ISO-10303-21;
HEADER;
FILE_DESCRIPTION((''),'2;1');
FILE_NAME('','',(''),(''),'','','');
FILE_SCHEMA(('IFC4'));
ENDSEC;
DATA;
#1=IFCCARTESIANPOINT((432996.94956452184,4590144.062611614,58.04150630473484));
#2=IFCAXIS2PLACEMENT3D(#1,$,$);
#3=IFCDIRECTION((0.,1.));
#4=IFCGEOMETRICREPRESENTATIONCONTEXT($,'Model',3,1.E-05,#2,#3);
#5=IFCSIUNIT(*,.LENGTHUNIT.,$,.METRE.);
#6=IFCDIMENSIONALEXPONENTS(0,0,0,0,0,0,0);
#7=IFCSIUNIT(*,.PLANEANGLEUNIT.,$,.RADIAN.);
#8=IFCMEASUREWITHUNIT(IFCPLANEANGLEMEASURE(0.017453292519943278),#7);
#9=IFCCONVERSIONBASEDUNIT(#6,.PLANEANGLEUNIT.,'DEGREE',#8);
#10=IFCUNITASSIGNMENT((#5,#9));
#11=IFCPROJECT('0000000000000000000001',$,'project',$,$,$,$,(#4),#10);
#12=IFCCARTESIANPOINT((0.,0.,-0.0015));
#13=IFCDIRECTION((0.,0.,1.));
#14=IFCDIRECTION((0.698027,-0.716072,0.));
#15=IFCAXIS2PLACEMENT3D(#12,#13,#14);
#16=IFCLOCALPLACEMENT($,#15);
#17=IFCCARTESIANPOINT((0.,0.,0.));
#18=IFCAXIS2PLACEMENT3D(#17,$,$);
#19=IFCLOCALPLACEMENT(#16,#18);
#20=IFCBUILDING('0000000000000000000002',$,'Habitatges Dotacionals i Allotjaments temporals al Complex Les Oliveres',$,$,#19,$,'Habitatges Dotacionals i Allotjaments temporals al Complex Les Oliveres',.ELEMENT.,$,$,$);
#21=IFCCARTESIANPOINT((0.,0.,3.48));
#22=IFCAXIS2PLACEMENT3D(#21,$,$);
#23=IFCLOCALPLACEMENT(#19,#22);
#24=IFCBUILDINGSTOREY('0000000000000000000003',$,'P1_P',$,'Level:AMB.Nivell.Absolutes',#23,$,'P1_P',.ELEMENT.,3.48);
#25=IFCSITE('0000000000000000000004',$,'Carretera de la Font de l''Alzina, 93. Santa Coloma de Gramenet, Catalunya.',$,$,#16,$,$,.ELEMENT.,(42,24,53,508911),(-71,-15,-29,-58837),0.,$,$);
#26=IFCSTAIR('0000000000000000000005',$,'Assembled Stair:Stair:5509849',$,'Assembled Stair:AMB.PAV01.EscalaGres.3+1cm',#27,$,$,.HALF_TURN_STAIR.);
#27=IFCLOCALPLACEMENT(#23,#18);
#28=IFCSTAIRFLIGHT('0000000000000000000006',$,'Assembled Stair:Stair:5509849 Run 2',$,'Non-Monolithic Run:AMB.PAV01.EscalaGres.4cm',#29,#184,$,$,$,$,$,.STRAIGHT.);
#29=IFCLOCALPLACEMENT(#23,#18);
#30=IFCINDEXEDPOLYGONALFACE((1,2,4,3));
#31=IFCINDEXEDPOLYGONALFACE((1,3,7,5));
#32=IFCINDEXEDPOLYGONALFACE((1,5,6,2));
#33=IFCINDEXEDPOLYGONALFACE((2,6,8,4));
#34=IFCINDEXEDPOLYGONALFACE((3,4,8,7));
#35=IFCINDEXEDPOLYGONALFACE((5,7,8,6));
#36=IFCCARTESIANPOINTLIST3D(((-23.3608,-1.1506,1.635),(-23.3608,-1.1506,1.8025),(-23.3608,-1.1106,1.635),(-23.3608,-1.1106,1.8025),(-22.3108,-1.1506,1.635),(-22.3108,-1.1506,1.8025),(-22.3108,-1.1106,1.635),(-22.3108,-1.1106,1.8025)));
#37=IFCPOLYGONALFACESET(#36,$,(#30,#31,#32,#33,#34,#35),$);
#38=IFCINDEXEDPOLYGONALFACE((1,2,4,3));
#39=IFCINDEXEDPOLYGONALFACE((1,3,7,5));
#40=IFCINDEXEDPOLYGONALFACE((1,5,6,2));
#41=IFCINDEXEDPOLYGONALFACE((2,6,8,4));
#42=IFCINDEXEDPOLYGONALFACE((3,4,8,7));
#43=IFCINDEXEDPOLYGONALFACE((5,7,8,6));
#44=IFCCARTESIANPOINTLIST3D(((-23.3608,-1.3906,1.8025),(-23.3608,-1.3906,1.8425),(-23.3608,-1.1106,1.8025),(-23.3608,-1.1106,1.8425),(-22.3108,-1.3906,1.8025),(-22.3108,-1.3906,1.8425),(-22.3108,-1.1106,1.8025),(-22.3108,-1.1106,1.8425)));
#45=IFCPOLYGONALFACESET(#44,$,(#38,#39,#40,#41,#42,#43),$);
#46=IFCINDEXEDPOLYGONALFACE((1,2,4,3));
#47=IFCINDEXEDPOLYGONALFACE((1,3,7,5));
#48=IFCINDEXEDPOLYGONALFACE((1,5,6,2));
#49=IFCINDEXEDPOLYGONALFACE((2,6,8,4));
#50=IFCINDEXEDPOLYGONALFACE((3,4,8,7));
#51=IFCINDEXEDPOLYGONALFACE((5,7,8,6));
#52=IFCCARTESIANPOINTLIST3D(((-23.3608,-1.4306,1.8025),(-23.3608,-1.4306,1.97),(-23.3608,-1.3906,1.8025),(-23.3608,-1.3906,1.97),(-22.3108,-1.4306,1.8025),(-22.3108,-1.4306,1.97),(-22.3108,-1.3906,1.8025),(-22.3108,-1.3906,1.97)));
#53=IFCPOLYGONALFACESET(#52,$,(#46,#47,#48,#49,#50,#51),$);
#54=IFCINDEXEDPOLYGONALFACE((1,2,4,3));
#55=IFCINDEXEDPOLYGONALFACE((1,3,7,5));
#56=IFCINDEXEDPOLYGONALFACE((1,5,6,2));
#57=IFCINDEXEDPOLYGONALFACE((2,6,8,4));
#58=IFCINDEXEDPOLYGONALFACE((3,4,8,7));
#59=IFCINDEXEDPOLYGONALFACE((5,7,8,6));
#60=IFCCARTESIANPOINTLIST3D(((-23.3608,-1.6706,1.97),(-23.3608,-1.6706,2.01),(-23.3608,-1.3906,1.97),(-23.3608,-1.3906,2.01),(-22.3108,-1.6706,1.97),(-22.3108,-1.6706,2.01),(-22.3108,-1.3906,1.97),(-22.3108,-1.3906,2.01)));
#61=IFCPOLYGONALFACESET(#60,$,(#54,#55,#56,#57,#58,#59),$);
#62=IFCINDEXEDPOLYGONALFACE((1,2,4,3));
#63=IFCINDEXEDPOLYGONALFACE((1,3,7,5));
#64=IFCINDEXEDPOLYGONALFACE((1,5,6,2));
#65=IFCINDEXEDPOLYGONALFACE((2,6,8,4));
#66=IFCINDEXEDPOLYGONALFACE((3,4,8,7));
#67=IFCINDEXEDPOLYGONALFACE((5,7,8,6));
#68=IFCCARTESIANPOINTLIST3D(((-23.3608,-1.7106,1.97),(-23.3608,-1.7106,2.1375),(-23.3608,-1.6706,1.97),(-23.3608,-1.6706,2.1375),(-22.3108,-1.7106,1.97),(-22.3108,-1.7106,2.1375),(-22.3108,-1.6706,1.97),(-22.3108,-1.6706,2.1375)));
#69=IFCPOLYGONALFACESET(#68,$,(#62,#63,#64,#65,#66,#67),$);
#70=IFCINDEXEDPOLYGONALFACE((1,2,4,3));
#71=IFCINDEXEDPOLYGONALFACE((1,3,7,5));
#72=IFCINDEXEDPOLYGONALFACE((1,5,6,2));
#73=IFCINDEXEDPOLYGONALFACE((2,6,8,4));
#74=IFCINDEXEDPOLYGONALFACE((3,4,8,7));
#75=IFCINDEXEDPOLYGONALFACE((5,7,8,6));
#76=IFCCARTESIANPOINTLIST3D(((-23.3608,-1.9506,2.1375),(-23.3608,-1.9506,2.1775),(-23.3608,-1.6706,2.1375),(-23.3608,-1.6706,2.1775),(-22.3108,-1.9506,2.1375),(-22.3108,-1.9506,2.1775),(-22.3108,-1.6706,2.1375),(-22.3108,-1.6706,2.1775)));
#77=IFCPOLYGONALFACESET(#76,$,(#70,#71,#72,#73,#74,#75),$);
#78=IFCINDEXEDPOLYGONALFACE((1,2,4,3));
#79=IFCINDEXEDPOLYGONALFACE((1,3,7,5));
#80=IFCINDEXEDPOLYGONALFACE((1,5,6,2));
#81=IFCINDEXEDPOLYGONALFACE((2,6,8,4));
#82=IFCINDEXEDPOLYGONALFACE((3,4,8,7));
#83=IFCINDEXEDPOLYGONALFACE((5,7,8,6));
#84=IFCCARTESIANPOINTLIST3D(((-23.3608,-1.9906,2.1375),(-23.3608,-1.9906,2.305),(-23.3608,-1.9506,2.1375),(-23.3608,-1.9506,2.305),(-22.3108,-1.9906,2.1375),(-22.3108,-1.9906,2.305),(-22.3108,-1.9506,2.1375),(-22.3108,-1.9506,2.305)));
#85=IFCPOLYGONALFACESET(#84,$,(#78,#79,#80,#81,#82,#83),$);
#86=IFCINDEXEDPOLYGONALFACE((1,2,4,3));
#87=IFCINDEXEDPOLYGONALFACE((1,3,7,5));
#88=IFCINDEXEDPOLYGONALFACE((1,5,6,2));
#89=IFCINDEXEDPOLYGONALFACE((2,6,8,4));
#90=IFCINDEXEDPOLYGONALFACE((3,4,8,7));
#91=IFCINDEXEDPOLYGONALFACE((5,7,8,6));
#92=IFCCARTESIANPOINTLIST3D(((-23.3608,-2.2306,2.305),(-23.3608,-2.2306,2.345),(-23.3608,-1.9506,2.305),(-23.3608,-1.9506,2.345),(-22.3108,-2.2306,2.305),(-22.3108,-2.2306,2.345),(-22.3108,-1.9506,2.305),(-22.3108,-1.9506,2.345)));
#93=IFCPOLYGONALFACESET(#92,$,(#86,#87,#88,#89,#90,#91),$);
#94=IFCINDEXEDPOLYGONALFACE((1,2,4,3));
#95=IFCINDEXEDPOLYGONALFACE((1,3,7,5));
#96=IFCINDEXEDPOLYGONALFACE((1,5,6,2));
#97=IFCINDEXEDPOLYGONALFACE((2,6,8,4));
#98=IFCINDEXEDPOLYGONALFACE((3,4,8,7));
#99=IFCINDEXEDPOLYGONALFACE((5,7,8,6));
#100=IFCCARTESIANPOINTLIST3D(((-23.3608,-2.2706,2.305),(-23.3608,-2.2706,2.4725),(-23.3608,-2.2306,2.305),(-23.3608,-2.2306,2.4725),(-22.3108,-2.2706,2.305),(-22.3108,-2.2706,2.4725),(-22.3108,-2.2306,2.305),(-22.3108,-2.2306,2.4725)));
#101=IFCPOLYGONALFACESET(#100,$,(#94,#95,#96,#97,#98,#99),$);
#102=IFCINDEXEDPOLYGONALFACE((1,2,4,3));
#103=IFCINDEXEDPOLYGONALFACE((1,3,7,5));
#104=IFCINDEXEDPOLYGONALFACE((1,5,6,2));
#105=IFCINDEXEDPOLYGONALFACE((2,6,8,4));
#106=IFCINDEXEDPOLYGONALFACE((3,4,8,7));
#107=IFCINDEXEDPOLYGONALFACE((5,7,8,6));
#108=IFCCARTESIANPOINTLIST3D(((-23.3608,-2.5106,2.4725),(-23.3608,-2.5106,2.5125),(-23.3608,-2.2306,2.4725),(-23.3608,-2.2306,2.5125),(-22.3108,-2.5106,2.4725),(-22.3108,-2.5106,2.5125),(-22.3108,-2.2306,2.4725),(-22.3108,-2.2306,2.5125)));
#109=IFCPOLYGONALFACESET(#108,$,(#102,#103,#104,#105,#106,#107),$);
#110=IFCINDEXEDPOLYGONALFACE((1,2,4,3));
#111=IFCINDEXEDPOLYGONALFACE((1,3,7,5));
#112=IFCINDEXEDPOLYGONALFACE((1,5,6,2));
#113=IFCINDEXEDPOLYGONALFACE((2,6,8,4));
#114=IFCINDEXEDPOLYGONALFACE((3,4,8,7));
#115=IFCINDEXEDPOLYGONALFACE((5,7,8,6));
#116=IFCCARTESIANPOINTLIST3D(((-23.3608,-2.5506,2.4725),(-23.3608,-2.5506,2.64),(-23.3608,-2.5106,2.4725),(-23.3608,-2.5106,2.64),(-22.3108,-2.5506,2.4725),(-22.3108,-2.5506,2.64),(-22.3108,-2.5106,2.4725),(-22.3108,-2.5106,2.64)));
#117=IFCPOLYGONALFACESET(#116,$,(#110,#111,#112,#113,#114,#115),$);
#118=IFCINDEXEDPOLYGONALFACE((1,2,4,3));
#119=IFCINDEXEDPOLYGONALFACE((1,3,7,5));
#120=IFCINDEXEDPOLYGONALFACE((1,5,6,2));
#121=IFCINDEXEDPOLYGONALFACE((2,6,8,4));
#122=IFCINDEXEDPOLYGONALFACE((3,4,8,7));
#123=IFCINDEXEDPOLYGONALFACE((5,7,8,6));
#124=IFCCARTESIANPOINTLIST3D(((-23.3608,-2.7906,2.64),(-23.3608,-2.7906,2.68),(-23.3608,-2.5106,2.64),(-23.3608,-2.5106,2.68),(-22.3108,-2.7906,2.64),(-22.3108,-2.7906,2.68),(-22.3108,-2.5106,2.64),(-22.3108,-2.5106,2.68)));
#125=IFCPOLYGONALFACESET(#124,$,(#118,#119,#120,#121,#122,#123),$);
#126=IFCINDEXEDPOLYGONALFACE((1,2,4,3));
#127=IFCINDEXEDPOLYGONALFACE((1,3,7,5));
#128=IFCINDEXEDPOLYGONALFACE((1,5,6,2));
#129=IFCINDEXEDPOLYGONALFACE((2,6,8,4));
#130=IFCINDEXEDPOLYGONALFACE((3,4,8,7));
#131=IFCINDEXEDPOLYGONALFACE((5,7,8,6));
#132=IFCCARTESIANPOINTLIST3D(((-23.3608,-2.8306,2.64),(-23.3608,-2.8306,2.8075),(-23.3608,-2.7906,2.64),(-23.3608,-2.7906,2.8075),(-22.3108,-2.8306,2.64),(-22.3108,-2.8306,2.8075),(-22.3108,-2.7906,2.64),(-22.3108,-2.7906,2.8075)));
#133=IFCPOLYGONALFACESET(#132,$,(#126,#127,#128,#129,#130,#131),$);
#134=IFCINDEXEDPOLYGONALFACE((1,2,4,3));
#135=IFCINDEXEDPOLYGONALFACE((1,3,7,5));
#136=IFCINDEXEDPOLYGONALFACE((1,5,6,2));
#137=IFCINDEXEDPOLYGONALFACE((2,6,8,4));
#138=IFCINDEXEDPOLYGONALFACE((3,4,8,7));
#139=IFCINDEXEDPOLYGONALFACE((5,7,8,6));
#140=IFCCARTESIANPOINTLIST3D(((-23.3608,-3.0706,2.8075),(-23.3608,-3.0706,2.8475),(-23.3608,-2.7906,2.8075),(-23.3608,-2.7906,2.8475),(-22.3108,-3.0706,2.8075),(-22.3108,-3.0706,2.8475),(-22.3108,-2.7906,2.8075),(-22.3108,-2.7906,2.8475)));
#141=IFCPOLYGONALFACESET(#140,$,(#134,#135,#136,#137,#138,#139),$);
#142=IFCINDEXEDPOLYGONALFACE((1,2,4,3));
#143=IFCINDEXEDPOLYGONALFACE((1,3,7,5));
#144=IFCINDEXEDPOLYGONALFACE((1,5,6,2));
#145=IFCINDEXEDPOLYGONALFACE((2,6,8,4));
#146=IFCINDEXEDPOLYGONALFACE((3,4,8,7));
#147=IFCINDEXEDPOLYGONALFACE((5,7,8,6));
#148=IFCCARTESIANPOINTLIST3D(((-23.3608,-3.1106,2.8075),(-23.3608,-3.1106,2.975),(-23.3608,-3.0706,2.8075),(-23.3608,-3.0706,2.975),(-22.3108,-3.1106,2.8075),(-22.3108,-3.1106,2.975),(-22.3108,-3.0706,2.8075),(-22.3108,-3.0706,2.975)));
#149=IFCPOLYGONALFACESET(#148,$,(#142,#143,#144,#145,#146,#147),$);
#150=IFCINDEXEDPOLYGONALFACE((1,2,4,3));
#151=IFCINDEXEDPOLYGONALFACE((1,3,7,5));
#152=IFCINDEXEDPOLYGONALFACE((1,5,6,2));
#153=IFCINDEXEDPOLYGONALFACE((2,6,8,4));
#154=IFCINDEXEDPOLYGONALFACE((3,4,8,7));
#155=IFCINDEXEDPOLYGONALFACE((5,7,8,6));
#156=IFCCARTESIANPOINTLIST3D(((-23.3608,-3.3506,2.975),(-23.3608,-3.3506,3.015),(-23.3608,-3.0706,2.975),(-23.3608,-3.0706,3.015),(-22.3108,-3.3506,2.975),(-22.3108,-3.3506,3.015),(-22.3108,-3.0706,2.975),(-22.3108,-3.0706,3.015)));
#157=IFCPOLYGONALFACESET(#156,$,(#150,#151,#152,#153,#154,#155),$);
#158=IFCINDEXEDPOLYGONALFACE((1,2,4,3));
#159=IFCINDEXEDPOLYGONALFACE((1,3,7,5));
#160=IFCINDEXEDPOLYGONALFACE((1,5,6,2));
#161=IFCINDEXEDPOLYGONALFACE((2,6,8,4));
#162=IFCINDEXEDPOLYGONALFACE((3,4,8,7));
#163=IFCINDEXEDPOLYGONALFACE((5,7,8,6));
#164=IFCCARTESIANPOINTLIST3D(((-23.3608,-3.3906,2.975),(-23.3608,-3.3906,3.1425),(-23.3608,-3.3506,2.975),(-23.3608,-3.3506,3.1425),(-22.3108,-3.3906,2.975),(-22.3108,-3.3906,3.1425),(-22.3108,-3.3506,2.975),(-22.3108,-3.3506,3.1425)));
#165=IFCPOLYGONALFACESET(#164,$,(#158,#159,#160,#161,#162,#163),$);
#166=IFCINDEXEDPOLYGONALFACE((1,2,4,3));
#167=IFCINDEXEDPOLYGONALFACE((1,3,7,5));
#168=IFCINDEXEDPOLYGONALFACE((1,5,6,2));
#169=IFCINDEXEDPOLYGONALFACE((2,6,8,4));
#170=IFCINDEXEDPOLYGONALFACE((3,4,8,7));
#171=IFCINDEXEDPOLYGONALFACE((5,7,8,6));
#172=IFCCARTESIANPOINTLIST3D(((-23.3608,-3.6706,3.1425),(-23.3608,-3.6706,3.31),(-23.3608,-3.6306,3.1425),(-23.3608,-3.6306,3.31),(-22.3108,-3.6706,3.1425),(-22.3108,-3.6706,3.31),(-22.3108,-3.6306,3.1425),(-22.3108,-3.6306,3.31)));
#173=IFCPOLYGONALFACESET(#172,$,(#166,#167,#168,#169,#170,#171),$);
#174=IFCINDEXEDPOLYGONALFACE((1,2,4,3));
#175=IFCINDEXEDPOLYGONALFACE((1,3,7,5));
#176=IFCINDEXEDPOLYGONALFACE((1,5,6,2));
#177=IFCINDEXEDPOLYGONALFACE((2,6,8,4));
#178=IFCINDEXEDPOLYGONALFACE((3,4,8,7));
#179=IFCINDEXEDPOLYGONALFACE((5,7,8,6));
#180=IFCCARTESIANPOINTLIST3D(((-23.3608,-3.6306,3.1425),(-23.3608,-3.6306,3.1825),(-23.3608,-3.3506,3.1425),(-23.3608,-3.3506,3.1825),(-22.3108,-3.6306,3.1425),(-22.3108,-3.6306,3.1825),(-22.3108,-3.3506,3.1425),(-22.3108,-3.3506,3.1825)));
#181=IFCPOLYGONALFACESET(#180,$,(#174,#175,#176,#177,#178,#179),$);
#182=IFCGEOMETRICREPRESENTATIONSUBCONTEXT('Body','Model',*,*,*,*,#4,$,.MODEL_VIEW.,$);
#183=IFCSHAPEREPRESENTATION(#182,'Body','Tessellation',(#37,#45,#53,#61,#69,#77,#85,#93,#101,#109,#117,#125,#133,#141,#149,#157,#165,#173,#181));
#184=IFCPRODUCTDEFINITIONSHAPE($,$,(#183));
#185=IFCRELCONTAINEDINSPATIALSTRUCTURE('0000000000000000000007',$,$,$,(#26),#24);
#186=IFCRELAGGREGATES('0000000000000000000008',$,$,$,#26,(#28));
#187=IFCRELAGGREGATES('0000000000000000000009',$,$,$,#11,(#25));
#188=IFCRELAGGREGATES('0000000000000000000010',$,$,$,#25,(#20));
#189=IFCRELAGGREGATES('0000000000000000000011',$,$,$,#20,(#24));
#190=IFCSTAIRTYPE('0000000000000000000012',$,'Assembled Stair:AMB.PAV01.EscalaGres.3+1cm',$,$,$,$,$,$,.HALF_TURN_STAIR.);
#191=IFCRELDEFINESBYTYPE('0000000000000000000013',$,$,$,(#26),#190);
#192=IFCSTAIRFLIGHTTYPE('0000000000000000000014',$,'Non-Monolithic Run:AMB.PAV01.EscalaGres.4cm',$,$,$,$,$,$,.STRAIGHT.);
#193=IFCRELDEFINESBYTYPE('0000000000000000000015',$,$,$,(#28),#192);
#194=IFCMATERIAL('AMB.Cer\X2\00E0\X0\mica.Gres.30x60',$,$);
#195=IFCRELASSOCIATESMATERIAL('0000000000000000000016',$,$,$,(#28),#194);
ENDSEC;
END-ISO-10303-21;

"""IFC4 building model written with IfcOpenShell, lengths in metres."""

from ifc_helpers import new_model, entity, si_unit, converted_unit, direction, frame, origin, place, context, subcontext, project, spatial, indexed_curve, outline, extrude, material, type_object, element, aggregate, save


model = new_model("IFC4")

# Units and contexts
model_context = context("Model", 3, precision=1e-05, world=frame((432996.94956452184, 4590144.062611614, 58.04150630473484)), true_north=direction((0.0, 1.0)))
body_context = subcontext(model_context, "Body", "Model", "MODEL_VIEW")
ifc_project = project(units=[si_unit("LENGTHUNIT", "METRE"), converted_unit("PLANEANGLEUNIT", "DEGREE", entity("IfcPlaneAngleMeasure", 0.017453292519943278), si_unit("PLANEANGLEUNIT", "RADIAN"), dimensions=[0, 0, 0, 0, 0, 0, 0])], contexts=[model_context])

# Site, building, storey
site_placement = place(None, frame((0.0, 0.0, -0.0015), z_axis=(0.0, 0.0, 1.0), x_axis=(0.698027, -0.716072, 0.0)))
site = spatial("IfcSite", under=ifc_project, at=site_placement, Name="Carretera de la Font de l'Alzina, 93. Santa Coloma de Gramenet, Catalunya.", CompositionType="ELEMENT", RefLatitude=(42, 24, 53, 508911), RefLongitude=(-71, -15, -29, -58837), RefElevation=0.0)
building_placement = place(site_placement, origin())
building = spatial("IfcBuilding", under=site, at=building_placement, Name="Habitatges Dotacionals i Allotjaments temporals al Complex Les Oliveres", LongName="Habitatges Dotacionals i Allotjaments temporals al Complex Les Oliveres", CompositionType="ELEMENT")
storey_placement = place(building_placement, frame((0.0, 0.0, 3.48)))
storey = spatial("IfcBuildingStorey", under=building, at=storey_placement, Name="P1_P", ObjectType="Level:AMB.Nivell.Absolutes", LongName="P1_P", CompositionType="ELEMENT", Elevation=3.48)

# Stair
stair_type_1 = type_object("IfcStairType", Name="Assembled Stair:AMB.PAV01.EscalaGres.3+1cm", PredefinedType="HALF_TURN_STAIR")
stair_1_placement = place(storey_placement, origin())
stair_1 = element("IfcStair", 1, at=stair_1_placement, inside=storey, type_object=stair_type_1, Name="Assembled Stair:Stair:5509849", ObjectType="Assembled Stair:AMB.PAV01.EscalaGres.3+1cm", PredefinedType="HALF_TURN_STAIR")
ifc_material_1 = material(Name="AMB.Ceràmica.Gres.30x60")

# Shared definitions
stair_flight_type = type_object("IfcStairFlightType", Name="Non-Monolithic Run:AMB.PAV01.EscalaGres.4cm", PredefinedType="STRAIGHT")

# Stair flight
stair_flight_1_placement = place(stair_1_placement, origin())
stair_flight_1 = element("IfcStairFlight", 2, at=stair_flight_1_placement, type_object=stair_flight_type, material=ifc_material_1, Name="Assembled Stair:Stair:5509849 Run 2", ObjectType="Non-Monolithic Run:AMB.PAV01.EscalaGres.4cm", PredefinedType="STRAIGHT", context=body_context, shape_type="SweptSolid", body=[
    extrude(outline(indexed_curve([(-0.525, -0.02), (0.525, -0.02), (0.525, 0.02), (-0.525, 0.02), (-0.525, -0.02)], self_intersect=False)), frame((-22.8358, -1.1306, 1.635)), (0.0, 0.0, 1.0), 0.1675),
    extrude(outline(indexed_curve([(-0.14, -0.525), (0.14, -0.525), (0.14, 0.525), (-0.14, 0.525), (-0.14, -0.525)], self_intersect=False)), frame((-22.8358, -1.2506, 1.8025), z_axis=(0.0, 0.0, 1.0), x_axis=(0.0, 1.0, 0.0)), (0.0, 0.0, 1.0), 0.04),
    extrude(outline(indexed_curve([(-0.525, -0.02), (0.525, -0.02), (0.525, 0.02), (-0.525, 0.02), (-0.525, -0.02)], self_intersect=False)), frame((-22.8358, -1.4106, 1.8025)), (0.0, 0.0, 1.0), 0.1675),
    extrude(outline(indexed_curve([(-0.14, -0.525), (0.14, -0.525), (0.14, 0.525), (-0.14, 0.525), (-0.14, -0.525)], self_intersect=False)), frame((-22.8358, -1.5306, 1.97), z_axis=(0.0, 0.0, 1.0), x_axis=(0.0, 1.0, 0.0)), (0.0, 0.0, 1.0), 0.04),
    extrude(outline(indexed_curve([(-0.525, -0.02), (0.525, -0.02), (0.525, 0.02), (-0.525, 0.02), (-0.525, -0.02)], self_intersect=False)), frame((-22.8358, -1.6906, 1.97)), (0.0, 0.0, 1.0), 0.1675),
    extrude(outline(indexed_curve([(-0.14, -0.525), (0.14, -0.525), (0.14, 0.525), (-0.14, 0.525), (-0.14, -0.525)], self_intersect=False)), frame((-22.8358, -1.8106, 2.1375), z_axis=(0.0, 0.0, 1.0), x_axis=(0.0, 1.0, 0.0)), (0.0, 0.0, 1.0), 0.04),
    extrude(outline(indexed_curve([(-0.525, -0.02), (0.525, -0.02), (0.525, 0.02), (-0.525, 0.02), (-0.525, -0.02)], self_intersect=False)), frame((-22.8358, -1.9706, 2.1375)), (0.0, 0.0, 1.0), 0.1675),
    extrude(outline(indexed_curve([(-0.14, -0.525), (0.14, -0.525), (0.14, 0.525), (-0.14, 0.525), (-0.14, -0.525)], self_intersect=False)), frame((-22.8358, -2.0906, 2.305), z_axis=(0.0, 0.0, 1.0), x_axis=(0.0, 1.0, 0.0)), (0.0, 0.0, 1.0), 0.04),
    extrude(outline(indexed_curve([(-0.525, -0.02), (0.525, -0.02), (0.525, 0.02), (-0.525, 0.02), (-0.525, -0.02)], self_intersect=False)), frame((-22.8358, -2.2506, 2.305)), (0.0, 0.0, 1.0), 0.1675),
    extrude(outline(indexed_curve([(-0.14, -0.525), (0.14, -0.525), (0.14, 0.525), (-0.14, 0.525), (-0.14, -0.525)], self_intersect=False)), frame((-22.8358, -2.3706, 2.4725), z_axis=(0.0, 0.0, 1.0), x_axis=(0.0, 1.0, 0.0)), (0.0, 0.0, 1.0), 0.04),
    extrude(outline(indexed_curve([(-0.525, -0.02), (0.525, -0.02), (0.525, 0.02), (-0.525, 0.02), (-0.525, -0.02)], self_intersect=False)), frame((-22.8358, -2.5306, 2.4725)), (0.0, 0.0, 1.0), 0.1675),
    extrude(outline(indexed_curve([(-0.14, -0.525), (0.14, -0.525), (0.14, 0.525), (-0.14, 0.525), (-0.14, -0.525)], self_intersect=False)), frame((-22.8358, -2.6506, 2.64), z_axis=(0.0, 0.0, 1.0), x_axis=(0.0, 1.0, 0.0)), (0.0, 0.0, 1.0), 0.04),
    extrude(outline(indexed_curve([(-0.525, -0.02), (0.525, -0.02), (0.525, 0.02), (-0.525, 0.02), (-0.525, -0.02)], self_intersect=False)), frame((-22.8358, -2.8106, 2.64)), (0.0, 0.0, 1.0), 0.1675),
    extrude(outline(indexed_curve([(-0.14, -0.525), (0.14, -0.525), (0.14, 0.525), (-0.14, 0.525), (-0.14, -0.525)], self_intersect=False)), frame((-22.8358, -2.9306, 2.8075), z_axis=(0.0, 0.0, 1.0), x_axis=(0.0, 1.0, 0.0)), (0.0, 0.0, 1.0), 0.04),
    extrude(outline(indexed_curve([(-0.525, -0.02), (0.525, -0.02), (0.525, 0.02), (-0.525, 0.02), (-0.525, -0.02)], self_intersect=False)), frame((-22.8358, -3.0906, 2.8075)), (0.0, 0.0, 1.0), 0.1675),
    extrude(outline(indexed_curve([(-0.14, -0.525), (0.14, -0.525), (0.14, 0.525), (-0.14, 0.525), (-0.14, -0.525)], self_intersect=False)), frame((-22.8358, -3.2106, 2.975), z_axis=(0.0, 0.0, 1.0), x_axis=(0.0, 1.0, 0.0)), (0.0, 0.0, 1.0), 0.04),
    extrude(outline(indexed_curve([(-0.525, -0.02), (0.525, -0.02), (0.525, 0.02), (-0.525, 0.02), (-0.525, -0.02)], self_intersect=False)), frame((-22.8358, -3.3706, 2.975)), (0.0, 0.0, 1.0), 0.1675),
    extrude(outline(indexed_curve([(-0.525, -0.02), (0.525, -0.02), (0.525, 0.02), (-0.525, 0.02), (-0.525, -0.02)], self_intersect=False)), frame((-22.8358, -3.6506, 3.1425)), (0.0, 0.0, 1.0), 0.1675),
    extrude(outline(indexed_curve([(-0.14, -0.525), (0.14, -0.525), (0.14, 0.525), (-0.14, 0.525), (-0.14, -0.525)], self_intersect=False)), frame((-22.8358, -3.4906, 3.1425), z_axis=(0.0, 0.0, 1.0), x_axis=(0.0, 1.0, 0.0)), (0.0, 0.0, 1.0), 0.04),
])
aggregate(stair_1, [stair_flight_1])

save(model, "model.ifc")
